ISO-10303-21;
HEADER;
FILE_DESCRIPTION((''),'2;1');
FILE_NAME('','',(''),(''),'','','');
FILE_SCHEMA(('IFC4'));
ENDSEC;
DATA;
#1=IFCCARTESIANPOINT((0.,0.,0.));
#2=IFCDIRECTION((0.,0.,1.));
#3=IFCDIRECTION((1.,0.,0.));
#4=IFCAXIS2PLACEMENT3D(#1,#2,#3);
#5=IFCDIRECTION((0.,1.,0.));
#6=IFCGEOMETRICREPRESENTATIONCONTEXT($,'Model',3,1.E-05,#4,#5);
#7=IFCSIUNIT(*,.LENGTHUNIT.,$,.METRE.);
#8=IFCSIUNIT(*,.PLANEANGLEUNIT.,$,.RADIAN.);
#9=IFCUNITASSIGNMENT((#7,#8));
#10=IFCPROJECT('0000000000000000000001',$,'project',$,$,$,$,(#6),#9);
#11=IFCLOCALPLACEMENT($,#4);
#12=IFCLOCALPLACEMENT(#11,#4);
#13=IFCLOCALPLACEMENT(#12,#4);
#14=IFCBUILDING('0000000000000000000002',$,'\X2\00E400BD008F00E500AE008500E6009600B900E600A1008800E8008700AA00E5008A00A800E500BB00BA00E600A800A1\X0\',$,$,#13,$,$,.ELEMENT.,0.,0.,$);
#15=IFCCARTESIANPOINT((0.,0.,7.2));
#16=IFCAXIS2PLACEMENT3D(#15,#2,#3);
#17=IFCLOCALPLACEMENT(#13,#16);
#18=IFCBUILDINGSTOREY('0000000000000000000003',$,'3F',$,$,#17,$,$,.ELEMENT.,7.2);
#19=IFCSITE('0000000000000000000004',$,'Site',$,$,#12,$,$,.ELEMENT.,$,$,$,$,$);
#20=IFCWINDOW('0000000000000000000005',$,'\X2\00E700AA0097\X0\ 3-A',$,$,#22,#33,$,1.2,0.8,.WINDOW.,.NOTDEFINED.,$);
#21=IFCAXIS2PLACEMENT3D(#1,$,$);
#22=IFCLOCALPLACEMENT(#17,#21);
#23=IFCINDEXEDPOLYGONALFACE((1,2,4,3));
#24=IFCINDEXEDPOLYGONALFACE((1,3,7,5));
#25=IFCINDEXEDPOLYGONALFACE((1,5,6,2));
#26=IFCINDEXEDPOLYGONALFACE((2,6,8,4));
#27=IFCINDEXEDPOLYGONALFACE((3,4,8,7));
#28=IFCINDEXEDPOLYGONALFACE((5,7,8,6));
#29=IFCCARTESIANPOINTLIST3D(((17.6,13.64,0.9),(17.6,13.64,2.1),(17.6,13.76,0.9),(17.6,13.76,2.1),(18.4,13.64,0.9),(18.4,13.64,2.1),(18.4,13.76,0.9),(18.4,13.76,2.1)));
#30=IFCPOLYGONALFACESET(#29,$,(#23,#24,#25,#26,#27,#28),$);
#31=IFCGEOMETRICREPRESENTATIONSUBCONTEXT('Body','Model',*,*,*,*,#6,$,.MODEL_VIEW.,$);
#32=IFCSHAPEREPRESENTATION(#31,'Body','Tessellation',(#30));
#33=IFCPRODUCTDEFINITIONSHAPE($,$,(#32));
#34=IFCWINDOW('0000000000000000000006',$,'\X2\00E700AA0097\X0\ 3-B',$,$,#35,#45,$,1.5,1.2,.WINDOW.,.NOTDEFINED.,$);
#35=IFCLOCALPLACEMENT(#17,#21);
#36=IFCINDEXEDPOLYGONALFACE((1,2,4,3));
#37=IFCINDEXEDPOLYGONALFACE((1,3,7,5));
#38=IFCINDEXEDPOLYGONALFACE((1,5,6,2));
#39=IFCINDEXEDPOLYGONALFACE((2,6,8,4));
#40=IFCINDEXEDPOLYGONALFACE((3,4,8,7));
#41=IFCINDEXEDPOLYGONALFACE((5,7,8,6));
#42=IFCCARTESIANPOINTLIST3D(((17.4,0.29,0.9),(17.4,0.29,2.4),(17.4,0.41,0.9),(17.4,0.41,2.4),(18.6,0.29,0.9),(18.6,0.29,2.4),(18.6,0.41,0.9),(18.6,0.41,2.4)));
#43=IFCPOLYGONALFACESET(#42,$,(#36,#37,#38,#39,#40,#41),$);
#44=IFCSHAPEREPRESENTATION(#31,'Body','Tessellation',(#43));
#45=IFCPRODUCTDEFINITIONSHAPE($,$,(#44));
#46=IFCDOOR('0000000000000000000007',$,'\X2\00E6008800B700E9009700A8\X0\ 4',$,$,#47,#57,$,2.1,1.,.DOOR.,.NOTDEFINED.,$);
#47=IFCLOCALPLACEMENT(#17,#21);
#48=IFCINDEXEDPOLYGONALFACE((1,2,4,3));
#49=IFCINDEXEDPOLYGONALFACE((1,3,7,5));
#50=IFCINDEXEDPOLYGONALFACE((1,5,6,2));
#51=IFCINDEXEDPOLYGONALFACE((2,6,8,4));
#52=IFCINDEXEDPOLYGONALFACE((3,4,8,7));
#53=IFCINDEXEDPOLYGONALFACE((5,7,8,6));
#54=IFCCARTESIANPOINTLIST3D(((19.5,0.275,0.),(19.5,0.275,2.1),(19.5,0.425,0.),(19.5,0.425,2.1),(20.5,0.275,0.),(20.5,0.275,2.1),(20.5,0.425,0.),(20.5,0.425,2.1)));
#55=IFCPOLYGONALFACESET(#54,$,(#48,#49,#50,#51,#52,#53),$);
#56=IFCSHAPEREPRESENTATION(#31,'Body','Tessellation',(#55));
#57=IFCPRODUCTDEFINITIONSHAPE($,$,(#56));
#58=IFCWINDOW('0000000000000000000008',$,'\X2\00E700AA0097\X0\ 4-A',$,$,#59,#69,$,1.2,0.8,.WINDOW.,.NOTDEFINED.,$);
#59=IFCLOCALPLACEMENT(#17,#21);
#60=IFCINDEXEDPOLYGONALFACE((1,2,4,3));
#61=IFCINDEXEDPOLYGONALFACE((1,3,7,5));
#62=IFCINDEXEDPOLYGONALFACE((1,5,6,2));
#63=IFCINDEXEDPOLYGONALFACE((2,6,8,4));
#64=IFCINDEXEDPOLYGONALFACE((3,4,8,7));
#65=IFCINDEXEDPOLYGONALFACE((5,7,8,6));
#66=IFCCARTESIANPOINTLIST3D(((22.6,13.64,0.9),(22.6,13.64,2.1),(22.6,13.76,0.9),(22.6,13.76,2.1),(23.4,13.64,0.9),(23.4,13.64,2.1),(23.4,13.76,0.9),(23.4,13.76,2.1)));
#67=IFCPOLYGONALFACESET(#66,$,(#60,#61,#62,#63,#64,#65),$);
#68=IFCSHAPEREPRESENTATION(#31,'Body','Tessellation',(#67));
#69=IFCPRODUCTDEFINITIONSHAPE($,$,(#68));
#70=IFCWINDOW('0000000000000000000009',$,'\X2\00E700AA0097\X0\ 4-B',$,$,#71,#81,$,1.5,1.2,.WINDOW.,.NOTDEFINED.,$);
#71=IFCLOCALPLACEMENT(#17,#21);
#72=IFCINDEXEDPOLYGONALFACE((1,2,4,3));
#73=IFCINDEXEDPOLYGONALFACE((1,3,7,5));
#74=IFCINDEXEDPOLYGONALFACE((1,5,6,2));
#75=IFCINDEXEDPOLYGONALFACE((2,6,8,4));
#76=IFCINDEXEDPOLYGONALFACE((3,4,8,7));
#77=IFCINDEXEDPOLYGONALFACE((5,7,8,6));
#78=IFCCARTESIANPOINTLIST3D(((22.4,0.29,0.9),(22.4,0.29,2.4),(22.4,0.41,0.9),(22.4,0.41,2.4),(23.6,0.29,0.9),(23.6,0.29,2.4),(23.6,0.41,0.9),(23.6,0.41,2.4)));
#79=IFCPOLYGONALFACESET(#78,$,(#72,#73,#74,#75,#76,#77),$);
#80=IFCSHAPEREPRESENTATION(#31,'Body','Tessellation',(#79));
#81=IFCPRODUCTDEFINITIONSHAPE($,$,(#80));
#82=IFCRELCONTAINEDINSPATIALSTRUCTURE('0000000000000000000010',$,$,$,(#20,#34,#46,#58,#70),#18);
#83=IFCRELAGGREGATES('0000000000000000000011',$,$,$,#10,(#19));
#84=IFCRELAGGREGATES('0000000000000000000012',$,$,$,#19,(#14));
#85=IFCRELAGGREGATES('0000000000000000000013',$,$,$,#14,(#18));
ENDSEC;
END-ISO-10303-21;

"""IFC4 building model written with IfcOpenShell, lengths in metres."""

from ifc_helpers import new_model, si_unit, direction, frame, frame_2d, origin_with_axes, place, context, subcontext, project, spatial, rectangle, extrude, element, save


model = new_model("IFC4")

# Units and contexts
model_context = context("Model", 3, precision=1e-05, world=origin_with_axes(), true_north=direction((0.0, 1.0, 0.0)))
body_context = subcontext(model_context, "Body", "Model", "MODEL_VIEW")
ifc_project = project(units=[si_unit("LENGTHUNIT", "METRE"), si_unit("PLANEANGLEUNIT", "RADIAN")], contexts=[model_context])

# Site, building, storey
placement = place(None, origin_with_axes())
site_placement = place(placement, origin_with_axes())
site = spatial("IfcSite", under=ifc_project, at=site_placement, Name="Site", CompositionType="ELEMENT")
building_placement = place(site_placement, origin_with_axes())
building = spatial("IfcBuilding", under=site, at=building_placement, Name="ä½\u008få®\u0085æ\u0096¹æ¡\u0088è\u0087ªå\u008a¨å»ºæ¨¡", CompositionType="ELEMENT", ElevationOfRefHeight=0.0, ElevationOfTerrain=0.0)
storey_placement = place(building_placement, frame((0.0, 0.0, 7.2), z_axis=(0.0, 0.0, 1.0), x_axis=(1.0, 0.0, 0.0)))
storey = spatial("IfcBuildingStorey", under=building, at=storey_placement, Name="3F", CompositionType="ELEMENT", Elevation=7.2)

# Windows
window_1_placement = place(storey_placement, frame((18.0, 13.7, 0.9), z_axis=(0.0, 0.0, 1.0), x_axis=(1.0, 0.0, 0.0)))
element("IfcWindow", 1, at=window_1_placement, inside=storey, Name="çª\u0097 3-A", OverallHeight=1.2, OverallWidth=0.8, PartitioningType="NOTDEFINED", PredefinedType="WINDOW", context=body_context, shape_type="SweptSolid", body=[
    extrude(rectangle(XDim=0.8, YDim=0.12, at=frame_2d((0.0, 0.0), x_axis=(1.0, 0.0, 0.0))), frame((0.0, 0.0, 0.0), z_axis=(0.0, 0.0, 1.0)), (0.0, 0.0, 1.0), 1.2),
])
window_2_placement = place(storey_placement, frame((18.0, 0.35, 0.9), z_axis=(0.0, 0.0, 1.0), x_axis=(1.0, 0.0, 0.0)))
element("IfcWindow", 2, at=window_2_placement, inside=storey, Name="çª\u0097 3-B", OverallHeight=1.5, OverallWidth=1.2, PartitioningType="NOTDEFINED", PredefinedType="WINDOW", context=body_context, shape_type="SweptSolid", body=[
    extrude(rectangle(XDim=1.2, YDim=0.12, at=frame_2d((0.0, 0.0), x_axis=(1.0, 0.0, 0.0))), frame((0.0, 0.0, 0.0), z_axis=(0.0, 0.0, 1.0)), (0.0, 0.0, 1.0), 1.5),
])

# Door
door_1_placement = place(storey_placement, frame((20.0, 0.35, 0.0), z_axis=(0.0, 0.0, 1.0), x_axis=(1.0, 0.0, 0.0)))
element("IfcDoor", 3, at=door_1_placement, inside=storey, Name="æ\u0088·é\u0097¨ 4", OperationType="NOTDEFINED", OverallHeight=2.1, OverallWidth=1.0, PredefinedType="DOOR", context=body_context, shape_type="SweptSolid", body=[
    extrude(rectangle(XDim=1.0, YDim=0.15, at=frame_2d((0.0, 0.0), x_axis=(1.0, 0.0, 0.0))), frame((0.0, 0.0, 0.0), z_axis=(0.0, 0.0, 1.0)), (0.0, 0.0, 1.0), 2.1),
])

# Windows
window_3_placement = place(storey_placement, frame((23.0, 13.7, 0.9), z_axis=(0.0, 0.0, 1.0), x_axis=(1.0, 0.0, 0.0)))
element("IfcWindow", 4, at=window_3_placement, inside=storey, Name="çª\u0097 4-A", OverallHeight=1.2, OverallWidth=0.8, PartitioningType="NOTDEFINED", PredefinedType="WINDOW", context=body_context, shape_type="SweptSolid", body=[
    extrude(rectangle(XDim=0.8, YDim=0.12, at=frame_2d((0.0, 0.0), x_axis=(1.0, 0.0, 0.0))), frame((0.0, 0.0, 0.0), z_axis=(0.0, 0.0, 1.0)), (0.0, 0.0, 1.0), 1.2),
])
window_4_placement = place(storey_placement, frame((23.0, 0.35, 0.9), z_axis=(0.0, 0.0, 1.0), x_axis=(1.0, 0.0, 0.0)))
element("IfcWindow", 5, at=window_4_placement, inside=storey, Name="çª\u0097 4-B", OverallHeight=1.5, OverallWidth=1.2, PartitioningType="NOTDEFINED", PredefinedType="WINDOW", context=body_context, shape_type="SweptSolid", body=[
    extrude(rectangle(XDim=1.2, YDim=0.12, at=frame_2d((0.0, 0.0), x_axis=(1.0, 0.0, 0.0))), frame((0.0, 0.0, 0.0), z_axis=(0.0, 0.0, 1.0)), (0.0, 0.0, 1.0), 1.5),
])

save(model, "model.ifc")
